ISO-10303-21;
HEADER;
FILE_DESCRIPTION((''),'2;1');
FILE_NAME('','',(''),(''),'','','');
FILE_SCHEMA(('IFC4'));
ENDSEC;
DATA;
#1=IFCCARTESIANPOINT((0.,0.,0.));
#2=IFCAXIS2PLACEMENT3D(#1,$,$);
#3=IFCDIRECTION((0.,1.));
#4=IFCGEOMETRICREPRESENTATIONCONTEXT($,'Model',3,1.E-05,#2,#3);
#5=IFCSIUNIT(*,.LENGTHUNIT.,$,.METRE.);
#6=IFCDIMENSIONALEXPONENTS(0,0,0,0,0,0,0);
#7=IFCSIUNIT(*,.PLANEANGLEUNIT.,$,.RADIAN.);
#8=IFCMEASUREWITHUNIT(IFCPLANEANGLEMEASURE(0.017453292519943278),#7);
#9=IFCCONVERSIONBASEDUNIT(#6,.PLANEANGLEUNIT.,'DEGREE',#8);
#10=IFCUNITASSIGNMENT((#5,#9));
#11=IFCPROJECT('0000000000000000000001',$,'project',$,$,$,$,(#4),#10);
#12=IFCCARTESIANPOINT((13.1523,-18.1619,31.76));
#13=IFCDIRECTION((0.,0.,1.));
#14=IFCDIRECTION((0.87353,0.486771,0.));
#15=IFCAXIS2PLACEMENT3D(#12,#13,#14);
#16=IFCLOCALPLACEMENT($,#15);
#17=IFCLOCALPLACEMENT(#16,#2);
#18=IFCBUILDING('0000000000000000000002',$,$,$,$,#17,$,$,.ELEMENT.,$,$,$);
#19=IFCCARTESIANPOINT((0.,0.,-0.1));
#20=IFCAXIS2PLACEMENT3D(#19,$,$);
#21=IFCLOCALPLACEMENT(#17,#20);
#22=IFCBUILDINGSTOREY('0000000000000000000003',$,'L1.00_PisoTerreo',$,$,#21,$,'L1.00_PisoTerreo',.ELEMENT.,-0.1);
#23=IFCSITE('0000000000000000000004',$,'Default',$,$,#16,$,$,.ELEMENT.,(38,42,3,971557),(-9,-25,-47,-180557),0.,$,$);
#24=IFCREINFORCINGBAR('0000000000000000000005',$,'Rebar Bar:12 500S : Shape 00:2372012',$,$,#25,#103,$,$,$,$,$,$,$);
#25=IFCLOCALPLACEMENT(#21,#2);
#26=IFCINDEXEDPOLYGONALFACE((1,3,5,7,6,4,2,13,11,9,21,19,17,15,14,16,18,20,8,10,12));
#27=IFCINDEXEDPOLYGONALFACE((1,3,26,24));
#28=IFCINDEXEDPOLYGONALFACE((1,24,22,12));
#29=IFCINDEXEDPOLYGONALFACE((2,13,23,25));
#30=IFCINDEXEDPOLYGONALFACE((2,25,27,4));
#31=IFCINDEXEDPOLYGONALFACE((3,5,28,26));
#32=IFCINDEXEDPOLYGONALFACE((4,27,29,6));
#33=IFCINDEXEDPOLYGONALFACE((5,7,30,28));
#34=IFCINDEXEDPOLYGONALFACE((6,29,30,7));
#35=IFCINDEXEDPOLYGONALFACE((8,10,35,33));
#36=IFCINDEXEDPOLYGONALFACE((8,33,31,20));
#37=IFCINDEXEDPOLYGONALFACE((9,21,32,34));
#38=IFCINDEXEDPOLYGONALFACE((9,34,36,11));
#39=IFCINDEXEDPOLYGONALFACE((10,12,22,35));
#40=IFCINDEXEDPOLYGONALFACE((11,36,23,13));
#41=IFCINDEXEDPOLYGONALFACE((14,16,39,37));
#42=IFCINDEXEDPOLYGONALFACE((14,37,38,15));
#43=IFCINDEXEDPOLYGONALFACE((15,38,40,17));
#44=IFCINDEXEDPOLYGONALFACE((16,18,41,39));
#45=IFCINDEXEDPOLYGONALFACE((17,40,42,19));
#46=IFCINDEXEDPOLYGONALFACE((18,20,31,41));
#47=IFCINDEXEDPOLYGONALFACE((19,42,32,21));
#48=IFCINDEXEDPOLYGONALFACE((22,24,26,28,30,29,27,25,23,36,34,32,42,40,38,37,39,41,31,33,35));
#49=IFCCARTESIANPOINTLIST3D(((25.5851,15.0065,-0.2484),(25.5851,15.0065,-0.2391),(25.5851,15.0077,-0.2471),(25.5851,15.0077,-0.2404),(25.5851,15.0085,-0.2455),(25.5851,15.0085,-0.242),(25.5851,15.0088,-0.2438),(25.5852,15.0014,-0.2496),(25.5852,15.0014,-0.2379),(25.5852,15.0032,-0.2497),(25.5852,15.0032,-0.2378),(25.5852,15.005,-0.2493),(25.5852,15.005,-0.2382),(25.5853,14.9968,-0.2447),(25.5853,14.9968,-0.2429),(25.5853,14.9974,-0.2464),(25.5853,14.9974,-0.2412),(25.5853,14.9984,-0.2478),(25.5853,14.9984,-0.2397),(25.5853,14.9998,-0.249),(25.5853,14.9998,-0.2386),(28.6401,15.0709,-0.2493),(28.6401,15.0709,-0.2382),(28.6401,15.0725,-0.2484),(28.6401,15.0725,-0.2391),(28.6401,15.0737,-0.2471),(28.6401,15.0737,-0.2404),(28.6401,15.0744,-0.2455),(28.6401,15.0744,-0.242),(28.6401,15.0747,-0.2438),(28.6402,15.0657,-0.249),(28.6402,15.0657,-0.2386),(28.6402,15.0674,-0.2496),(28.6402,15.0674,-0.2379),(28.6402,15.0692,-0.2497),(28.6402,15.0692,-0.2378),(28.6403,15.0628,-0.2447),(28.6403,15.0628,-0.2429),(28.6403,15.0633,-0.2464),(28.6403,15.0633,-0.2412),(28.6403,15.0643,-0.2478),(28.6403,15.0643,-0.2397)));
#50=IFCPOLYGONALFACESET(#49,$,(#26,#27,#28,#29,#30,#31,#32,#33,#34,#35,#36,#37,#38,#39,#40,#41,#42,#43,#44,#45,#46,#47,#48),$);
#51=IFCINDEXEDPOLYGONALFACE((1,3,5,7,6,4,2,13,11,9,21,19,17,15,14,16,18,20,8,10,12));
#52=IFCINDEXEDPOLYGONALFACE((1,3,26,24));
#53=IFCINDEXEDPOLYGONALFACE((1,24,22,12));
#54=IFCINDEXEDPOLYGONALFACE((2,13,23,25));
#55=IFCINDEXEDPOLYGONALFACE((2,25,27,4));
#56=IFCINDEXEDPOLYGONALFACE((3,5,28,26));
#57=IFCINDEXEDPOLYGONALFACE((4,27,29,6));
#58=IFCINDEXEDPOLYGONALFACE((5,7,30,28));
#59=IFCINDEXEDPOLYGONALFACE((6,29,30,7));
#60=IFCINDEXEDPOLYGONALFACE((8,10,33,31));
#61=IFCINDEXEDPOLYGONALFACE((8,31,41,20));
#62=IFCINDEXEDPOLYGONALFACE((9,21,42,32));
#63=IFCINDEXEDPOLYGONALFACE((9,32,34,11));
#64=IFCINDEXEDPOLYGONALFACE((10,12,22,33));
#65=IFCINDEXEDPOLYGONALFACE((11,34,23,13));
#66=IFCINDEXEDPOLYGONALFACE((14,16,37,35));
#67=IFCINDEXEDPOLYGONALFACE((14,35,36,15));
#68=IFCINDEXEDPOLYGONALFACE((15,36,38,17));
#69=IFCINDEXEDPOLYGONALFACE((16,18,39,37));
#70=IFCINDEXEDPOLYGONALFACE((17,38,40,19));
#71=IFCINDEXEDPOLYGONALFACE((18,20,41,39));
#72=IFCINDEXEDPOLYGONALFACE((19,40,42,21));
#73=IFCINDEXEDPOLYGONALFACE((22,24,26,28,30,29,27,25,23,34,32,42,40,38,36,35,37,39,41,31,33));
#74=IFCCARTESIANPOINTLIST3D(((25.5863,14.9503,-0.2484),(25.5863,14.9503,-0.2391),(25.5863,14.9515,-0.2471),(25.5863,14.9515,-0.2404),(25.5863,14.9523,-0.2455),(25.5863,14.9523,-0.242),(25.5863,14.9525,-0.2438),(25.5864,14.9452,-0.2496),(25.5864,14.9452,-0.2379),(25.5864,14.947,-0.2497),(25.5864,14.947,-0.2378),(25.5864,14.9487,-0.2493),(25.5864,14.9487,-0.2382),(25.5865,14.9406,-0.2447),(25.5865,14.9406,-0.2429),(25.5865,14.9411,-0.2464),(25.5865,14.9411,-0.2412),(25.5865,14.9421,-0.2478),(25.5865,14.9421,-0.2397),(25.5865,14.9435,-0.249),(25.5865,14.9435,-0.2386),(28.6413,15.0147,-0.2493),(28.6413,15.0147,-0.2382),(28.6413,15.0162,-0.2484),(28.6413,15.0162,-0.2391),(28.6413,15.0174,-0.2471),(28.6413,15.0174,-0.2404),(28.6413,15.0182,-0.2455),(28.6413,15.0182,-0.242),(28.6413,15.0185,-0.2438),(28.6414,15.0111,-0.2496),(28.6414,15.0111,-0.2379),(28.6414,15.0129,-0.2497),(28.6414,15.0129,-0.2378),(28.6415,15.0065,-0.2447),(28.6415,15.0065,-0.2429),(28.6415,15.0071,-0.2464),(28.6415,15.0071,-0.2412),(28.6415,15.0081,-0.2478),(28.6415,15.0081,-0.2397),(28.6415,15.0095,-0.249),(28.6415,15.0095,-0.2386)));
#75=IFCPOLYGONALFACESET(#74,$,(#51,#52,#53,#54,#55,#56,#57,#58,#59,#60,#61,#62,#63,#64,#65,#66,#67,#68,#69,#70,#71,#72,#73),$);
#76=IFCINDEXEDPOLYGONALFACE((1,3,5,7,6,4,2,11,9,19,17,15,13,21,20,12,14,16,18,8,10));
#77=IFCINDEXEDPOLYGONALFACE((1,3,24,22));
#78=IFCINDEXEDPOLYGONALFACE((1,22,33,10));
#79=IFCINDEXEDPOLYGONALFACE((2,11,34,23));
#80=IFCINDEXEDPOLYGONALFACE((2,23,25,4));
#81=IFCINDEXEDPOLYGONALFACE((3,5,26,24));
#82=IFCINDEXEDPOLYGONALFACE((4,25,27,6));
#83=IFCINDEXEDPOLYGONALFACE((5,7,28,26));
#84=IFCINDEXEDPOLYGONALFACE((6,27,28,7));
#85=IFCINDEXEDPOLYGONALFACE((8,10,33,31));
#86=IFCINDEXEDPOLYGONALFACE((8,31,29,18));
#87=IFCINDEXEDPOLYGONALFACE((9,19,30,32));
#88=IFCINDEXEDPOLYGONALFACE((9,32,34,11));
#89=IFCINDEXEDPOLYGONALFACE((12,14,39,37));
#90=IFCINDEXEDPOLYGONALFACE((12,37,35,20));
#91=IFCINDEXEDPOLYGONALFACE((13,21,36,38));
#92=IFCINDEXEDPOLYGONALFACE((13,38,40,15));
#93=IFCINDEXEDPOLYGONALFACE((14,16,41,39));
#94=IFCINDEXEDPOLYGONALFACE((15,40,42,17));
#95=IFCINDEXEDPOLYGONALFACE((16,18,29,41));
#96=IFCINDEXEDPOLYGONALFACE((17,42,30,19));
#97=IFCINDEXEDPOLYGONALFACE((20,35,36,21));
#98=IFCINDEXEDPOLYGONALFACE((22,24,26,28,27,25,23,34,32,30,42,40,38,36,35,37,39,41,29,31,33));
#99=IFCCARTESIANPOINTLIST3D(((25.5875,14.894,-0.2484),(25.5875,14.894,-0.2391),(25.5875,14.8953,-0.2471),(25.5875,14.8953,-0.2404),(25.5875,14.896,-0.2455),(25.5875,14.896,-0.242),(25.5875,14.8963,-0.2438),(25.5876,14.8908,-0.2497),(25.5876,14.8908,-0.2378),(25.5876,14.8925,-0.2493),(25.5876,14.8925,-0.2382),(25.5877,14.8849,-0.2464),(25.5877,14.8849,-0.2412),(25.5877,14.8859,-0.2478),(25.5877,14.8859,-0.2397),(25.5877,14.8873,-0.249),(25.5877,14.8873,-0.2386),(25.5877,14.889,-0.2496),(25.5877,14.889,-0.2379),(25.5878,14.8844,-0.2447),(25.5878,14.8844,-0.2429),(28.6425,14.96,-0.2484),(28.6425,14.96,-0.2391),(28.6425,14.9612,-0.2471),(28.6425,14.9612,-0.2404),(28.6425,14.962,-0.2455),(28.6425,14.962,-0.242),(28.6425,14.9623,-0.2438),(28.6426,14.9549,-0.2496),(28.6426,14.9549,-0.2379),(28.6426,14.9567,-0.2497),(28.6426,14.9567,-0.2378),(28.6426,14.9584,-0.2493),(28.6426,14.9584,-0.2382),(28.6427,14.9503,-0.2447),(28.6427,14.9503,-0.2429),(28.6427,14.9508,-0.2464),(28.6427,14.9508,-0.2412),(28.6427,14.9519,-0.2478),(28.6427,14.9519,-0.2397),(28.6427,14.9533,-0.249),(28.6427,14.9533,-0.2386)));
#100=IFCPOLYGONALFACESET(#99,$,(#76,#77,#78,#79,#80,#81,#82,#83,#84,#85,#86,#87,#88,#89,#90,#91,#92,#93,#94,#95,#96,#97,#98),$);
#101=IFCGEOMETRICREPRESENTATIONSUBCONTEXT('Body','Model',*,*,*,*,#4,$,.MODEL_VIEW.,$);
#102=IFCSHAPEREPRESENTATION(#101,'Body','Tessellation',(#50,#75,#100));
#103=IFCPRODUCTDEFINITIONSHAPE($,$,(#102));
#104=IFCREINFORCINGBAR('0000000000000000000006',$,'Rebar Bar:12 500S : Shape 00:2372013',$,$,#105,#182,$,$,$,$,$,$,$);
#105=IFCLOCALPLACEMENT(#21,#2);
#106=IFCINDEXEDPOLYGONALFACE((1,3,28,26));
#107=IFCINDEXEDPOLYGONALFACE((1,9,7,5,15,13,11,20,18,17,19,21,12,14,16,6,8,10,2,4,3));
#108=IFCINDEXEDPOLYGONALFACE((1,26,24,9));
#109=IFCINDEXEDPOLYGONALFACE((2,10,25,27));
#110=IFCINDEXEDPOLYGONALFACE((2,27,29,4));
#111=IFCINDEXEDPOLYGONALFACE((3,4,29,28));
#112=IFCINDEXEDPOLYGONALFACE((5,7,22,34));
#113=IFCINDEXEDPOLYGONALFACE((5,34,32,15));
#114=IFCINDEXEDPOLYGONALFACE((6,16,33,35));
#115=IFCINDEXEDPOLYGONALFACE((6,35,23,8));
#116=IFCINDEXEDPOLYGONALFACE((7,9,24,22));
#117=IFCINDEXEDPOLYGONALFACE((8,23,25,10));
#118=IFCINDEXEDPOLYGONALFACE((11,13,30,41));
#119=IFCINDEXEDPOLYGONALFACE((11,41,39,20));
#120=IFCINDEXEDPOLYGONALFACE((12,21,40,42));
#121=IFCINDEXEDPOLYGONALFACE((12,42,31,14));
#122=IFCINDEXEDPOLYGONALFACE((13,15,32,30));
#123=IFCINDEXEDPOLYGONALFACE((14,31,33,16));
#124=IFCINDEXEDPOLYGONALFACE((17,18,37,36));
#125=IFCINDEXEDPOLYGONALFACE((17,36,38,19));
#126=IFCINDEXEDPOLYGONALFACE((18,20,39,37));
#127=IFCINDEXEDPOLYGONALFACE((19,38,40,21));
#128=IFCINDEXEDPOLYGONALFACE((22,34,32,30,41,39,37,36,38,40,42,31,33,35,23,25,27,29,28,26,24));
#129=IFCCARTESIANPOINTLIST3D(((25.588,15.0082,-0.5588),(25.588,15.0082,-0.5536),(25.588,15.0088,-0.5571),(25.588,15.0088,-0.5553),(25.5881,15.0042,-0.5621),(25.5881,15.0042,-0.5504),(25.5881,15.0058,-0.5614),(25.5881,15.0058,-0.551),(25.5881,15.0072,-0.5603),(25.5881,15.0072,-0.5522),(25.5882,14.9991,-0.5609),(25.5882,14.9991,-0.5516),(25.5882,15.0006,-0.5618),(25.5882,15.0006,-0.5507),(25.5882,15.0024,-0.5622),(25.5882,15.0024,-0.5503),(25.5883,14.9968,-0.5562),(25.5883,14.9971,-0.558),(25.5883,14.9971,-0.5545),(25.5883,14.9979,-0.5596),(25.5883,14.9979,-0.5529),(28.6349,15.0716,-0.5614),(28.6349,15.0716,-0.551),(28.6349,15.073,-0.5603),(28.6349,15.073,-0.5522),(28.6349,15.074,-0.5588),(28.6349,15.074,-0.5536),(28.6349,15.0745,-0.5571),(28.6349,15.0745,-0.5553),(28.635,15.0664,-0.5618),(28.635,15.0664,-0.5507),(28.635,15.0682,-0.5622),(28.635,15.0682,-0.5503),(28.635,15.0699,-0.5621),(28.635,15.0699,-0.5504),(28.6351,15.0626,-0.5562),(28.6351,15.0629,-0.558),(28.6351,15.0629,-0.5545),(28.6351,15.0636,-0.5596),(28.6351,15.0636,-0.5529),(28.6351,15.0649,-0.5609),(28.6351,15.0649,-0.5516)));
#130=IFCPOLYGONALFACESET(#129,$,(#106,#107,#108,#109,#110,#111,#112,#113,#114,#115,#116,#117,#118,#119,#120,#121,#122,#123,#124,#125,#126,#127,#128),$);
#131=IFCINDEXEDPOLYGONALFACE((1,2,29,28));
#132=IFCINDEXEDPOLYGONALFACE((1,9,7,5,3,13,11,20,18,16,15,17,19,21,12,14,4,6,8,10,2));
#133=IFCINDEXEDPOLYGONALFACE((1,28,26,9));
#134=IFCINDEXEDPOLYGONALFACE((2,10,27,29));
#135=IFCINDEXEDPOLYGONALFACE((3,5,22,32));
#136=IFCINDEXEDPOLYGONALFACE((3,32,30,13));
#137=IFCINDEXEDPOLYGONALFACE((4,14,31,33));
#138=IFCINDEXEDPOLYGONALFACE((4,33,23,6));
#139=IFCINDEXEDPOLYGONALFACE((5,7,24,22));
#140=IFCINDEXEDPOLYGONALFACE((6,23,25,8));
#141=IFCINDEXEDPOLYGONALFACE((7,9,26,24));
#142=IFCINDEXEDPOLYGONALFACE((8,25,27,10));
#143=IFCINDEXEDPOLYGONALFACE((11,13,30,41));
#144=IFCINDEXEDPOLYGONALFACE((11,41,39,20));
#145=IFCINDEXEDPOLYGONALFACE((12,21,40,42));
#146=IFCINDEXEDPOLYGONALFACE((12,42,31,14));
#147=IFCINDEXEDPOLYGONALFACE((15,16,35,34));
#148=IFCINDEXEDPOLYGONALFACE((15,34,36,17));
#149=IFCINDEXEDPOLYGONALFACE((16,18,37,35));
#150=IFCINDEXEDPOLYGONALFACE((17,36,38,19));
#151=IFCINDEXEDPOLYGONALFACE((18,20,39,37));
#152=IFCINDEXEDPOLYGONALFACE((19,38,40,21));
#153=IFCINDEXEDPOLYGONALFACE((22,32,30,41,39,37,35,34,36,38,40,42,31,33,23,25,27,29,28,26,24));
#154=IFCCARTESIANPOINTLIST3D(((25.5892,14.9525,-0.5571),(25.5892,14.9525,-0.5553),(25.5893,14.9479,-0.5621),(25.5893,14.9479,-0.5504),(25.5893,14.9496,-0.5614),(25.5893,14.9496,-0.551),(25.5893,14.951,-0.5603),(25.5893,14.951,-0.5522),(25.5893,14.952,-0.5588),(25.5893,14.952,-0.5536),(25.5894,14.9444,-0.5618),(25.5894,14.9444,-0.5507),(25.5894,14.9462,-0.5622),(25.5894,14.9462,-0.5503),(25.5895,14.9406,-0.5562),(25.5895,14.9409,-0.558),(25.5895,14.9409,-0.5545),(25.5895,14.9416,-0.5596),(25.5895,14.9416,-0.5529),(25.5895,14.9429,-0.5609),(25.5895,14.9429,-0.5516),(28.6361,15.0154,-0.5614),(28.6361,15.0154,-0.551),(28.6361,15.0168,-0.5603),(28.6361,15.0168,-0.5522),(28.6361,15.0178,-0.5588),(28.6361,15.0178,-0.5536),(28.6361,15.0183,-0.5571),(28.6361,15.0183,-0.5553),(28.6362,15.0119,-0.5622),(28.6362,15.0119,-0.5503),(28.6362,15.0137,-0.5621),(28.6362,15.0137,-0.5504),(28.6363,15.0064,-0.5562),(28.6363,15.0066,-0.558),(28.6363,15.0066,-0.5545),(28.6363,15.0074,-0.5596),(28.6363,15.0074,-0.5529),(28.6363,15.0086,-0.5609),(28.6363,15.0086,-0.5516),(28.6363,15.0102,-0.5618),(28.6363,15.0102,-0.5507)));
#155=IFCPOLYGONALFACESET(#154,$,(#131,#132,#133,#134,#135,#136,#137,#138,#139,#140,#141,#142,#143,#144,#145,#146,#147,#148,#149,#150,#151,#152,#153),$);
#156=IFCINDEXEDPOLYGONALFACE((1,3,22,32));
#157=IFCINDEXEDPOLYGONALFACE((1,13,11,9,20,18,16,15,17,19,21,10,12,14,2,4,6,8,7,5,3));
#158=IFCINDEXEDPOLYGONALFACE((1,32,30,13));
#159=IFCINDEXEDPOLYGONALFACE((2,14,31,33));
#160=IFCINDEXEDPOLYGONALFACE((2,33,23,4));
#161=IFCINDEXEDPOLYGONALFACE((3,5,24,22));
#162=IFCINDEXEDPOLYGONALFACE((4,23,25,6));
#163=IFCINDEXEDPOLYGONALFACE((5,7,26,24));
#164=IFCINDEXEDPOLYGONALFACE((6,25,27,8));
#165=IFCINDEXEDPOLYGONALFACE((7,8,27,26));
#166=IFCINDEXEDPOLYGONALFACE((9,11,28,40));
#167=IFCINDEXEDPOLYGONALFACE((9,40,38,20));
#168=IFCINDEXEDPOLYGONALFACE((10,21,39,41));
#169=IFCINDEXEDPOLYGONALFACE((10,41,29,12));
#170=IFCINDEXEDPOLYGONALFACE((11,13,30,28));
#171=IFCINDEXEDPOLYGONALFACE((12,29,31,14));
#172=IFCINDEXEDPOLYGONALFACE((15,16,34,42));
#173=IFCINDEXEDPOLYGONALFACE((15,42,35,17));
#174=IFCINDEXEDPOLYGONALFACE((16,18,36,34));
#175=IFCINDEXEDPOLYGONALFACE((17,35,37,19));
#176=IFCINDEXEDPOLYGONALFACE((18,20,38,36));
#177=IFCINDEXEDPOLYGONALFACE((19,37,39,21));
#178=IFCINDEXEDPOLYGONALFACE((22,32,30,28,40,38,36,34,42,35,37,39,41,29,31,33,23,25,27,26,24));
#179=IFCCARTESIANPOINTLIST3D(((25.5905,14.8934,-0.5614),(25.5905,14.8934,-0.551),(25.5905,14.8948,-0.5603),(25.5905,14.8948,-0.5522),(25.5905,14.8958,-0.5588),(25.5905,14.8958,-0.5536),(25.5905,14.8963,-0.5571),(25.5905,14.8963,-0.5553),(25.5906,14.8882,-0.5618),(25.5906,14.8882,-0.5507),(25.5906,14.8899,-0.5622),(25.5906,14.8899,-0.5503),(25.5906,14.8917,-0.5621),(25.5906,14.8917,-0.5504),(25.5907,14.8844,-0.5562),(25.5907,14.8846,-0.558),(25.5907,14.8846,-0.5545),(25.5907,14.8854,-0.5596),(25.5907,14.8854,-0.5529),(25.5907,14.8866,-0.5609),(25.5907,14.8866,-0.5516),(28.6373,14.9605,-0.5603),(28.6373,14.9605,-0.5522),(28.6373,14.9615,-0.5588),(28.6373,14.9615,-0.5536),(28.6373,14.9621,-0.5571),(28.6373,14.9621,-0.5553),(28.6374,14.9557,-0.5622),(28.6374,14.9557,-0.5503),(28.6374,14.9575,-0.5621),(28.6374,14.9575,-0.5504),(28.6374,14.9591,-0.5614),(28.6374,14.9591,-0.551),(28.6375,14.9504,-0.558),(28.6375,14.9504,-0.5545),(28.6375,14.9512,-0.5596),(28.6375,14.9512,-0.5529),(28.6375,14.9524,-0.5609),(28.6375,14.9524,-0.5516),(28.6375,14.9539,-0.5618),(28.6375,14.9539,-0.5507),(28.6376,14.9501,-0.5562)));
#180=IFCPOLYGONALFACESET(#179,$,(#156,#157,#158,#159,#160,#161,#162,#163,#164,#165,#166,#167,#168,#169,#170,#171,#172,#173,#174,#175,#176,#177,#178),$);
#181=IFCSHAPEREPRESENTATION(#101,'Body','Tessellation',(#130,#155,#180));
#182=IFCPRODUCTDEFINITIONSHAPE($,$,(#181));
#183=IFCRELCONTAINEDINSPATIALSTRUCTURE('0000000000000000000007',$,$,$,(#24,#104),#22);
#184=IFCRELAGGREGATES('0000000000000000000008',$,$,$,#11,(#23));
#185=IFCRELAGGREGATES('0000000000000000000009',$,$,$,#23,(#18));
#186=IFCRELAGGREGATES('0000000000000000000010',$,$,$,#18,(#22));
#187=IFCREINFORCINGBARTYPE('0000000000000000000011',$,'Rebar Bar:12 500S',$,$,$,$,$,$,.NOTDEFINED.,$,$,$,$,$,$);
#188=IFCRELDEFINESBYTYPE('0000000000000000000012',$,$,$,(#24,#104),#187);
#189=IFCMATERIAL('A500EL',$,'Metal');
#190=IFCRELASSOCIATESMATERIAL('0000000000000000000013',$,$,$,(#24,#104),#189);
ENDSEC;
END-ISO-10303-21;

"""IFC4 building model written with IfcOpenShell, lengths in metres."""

from ifc_helpers import new_model, entity, si_unit, converted_unit, direction, frame, origin, place, context, subcontext, project, spatial, material, type_object, element, save


model = new_model("IFC4")

# Units and contexts
model_context = context("Model", 3, precision=1e-05, world=origin(), true_north=direction((0.0, 1.0)))
body_context = subcontext(model_context, "Body", "Model", "MODEL_VIEW")
ifc_project = project(units=[si_unit("LENGTHUNIT", "METRE"), converted_unit("PLANEANGLEUNIT", "DEGREE", entity("IfcPlaneAngleMeasure", 0.017453292519943278), si_unit("PLANEANGLEUNIT", "RADIAN"), dimensions=[0, 0, 0, 0, 0, 0, 0])], contexts=[model_context])

# Site, building, storey
site_placement = place(None, frame((13.1523, -18.1619, 31.76), z_axis=(0.0, 0.0, 1.0), x_axis=(0.87353, 0.486771, 0.0)))
site = spatial("IfcSite", under=ifc_project, at=site_placement, Name="Default", CompositionType="ELEMENT", RefLatitude=(38, 42, 3, 971557), RefLongitude=(-9, -25, -47, -180557), RefElevation=0.0)
building_placement = place(site_placement, origin())
building = spatial("IfcBuilding", under=site, at=building_placement, CompositionType="ELEMENT")
storey_placement = place(building_placement, frame((0.0, 0.0, -0.1)))
storey = spatial("IfcBuildingStorey", under=building, at=storey_placement, Name="L1.00_PisoTerreo", LongName="L1.00_PisoTerreo", CompositionType="ELEMENT", Elevation=-0.1)

# Reinforcing bars
ifc_material = material(Name="A500EL", Category="Metal")
reinforcing_bar_type_1 = type_object("IfcReinforcingBarType", Name="Rebar Bar:12 500S", PredefinedType="NOTDEFINED")
reinforcing_bar_1_placement = place(storey_placement, origin())
element("IfcReinforcingBar", 1, at=reinforcing_bar_1_placement, inside=storey, type_object=reinforcing_bar_type_1, material=ifc_material, Name="Rebar Bar:12 500S : Shape 00:2372012", context=body_context, shape_type="AdvancedSweptSolid", body=[
    entity("IfcSweptDiskSolid", entity("IfcIndexedPolyCurve", entity("IfcCartesianPointList3D", [[25.5852, 15.0028, -0.2438], [28.6402, 15.0687, -0.2438]]), None, False), 0.006, None, 0.0, 1.0),
    entity("IfcSweptDiskSolid", entity("IfcIndexedPolyCurve", entity("IfcCartesianPointList3D", [[25.5864, 14.9465, -0.2438], [28.6414, 15.0125, -0.2438]]), None, False), 0.006, None, 0.0, 1.0),
    entity("IfcSweptDiskSolid", entity("IfcIndexedPolyCurve", entity("IfcCartesianPointList3D", [[25.5876, 14.8903, -0.2438], [28.6426, 14.9563, -0.2438]]), None, False), 0.006, None, 0.0, 1.0),
])
reinforcing_bar_2_placement = place(storey_placement, origin())
element("IfcReinforcingBar", 2, at=reinforcing_bar_2_placement, inside=storey, type_object=reinforcing_bar_type_1, material=ifc_material, Name="Rebar Bar:12 500S : Shape 00:2372013", context=body_context, shape_type="AdvancedSweptSolid", body=[
    entity("IfcSweptDiskSolid", entity("IfcIndexedPolyCurve", entity("IfcCartesianPointList3D", [[28.635, 15.0686, -0.5562], [25.5882, 15.0028, -0.5562]]), None, False), 0.006, None, 0.0, 1.0),
    entity("IfcSweptDiskSolid", entity("IfcIndexedPolyCurve", entity("IfcCartesianPointList3D", [[28.6362, 15.0124, -0.5562], [25.5894, 14.9466, -0.5562]]), None, False), 0.006, None, 0.0, 1.0),
    entity("IfcSweptDiskSolid", entity("IfcIndexedPolyCurve", entity("IfcCartesianPointList3D", [[28.6374, 14.9561, -0.5562], [25.5906, 14.8904, -0.5562]]), None, False), 0.006, None, 0.0, 1.0),
])

save(model, "model.ifc")
